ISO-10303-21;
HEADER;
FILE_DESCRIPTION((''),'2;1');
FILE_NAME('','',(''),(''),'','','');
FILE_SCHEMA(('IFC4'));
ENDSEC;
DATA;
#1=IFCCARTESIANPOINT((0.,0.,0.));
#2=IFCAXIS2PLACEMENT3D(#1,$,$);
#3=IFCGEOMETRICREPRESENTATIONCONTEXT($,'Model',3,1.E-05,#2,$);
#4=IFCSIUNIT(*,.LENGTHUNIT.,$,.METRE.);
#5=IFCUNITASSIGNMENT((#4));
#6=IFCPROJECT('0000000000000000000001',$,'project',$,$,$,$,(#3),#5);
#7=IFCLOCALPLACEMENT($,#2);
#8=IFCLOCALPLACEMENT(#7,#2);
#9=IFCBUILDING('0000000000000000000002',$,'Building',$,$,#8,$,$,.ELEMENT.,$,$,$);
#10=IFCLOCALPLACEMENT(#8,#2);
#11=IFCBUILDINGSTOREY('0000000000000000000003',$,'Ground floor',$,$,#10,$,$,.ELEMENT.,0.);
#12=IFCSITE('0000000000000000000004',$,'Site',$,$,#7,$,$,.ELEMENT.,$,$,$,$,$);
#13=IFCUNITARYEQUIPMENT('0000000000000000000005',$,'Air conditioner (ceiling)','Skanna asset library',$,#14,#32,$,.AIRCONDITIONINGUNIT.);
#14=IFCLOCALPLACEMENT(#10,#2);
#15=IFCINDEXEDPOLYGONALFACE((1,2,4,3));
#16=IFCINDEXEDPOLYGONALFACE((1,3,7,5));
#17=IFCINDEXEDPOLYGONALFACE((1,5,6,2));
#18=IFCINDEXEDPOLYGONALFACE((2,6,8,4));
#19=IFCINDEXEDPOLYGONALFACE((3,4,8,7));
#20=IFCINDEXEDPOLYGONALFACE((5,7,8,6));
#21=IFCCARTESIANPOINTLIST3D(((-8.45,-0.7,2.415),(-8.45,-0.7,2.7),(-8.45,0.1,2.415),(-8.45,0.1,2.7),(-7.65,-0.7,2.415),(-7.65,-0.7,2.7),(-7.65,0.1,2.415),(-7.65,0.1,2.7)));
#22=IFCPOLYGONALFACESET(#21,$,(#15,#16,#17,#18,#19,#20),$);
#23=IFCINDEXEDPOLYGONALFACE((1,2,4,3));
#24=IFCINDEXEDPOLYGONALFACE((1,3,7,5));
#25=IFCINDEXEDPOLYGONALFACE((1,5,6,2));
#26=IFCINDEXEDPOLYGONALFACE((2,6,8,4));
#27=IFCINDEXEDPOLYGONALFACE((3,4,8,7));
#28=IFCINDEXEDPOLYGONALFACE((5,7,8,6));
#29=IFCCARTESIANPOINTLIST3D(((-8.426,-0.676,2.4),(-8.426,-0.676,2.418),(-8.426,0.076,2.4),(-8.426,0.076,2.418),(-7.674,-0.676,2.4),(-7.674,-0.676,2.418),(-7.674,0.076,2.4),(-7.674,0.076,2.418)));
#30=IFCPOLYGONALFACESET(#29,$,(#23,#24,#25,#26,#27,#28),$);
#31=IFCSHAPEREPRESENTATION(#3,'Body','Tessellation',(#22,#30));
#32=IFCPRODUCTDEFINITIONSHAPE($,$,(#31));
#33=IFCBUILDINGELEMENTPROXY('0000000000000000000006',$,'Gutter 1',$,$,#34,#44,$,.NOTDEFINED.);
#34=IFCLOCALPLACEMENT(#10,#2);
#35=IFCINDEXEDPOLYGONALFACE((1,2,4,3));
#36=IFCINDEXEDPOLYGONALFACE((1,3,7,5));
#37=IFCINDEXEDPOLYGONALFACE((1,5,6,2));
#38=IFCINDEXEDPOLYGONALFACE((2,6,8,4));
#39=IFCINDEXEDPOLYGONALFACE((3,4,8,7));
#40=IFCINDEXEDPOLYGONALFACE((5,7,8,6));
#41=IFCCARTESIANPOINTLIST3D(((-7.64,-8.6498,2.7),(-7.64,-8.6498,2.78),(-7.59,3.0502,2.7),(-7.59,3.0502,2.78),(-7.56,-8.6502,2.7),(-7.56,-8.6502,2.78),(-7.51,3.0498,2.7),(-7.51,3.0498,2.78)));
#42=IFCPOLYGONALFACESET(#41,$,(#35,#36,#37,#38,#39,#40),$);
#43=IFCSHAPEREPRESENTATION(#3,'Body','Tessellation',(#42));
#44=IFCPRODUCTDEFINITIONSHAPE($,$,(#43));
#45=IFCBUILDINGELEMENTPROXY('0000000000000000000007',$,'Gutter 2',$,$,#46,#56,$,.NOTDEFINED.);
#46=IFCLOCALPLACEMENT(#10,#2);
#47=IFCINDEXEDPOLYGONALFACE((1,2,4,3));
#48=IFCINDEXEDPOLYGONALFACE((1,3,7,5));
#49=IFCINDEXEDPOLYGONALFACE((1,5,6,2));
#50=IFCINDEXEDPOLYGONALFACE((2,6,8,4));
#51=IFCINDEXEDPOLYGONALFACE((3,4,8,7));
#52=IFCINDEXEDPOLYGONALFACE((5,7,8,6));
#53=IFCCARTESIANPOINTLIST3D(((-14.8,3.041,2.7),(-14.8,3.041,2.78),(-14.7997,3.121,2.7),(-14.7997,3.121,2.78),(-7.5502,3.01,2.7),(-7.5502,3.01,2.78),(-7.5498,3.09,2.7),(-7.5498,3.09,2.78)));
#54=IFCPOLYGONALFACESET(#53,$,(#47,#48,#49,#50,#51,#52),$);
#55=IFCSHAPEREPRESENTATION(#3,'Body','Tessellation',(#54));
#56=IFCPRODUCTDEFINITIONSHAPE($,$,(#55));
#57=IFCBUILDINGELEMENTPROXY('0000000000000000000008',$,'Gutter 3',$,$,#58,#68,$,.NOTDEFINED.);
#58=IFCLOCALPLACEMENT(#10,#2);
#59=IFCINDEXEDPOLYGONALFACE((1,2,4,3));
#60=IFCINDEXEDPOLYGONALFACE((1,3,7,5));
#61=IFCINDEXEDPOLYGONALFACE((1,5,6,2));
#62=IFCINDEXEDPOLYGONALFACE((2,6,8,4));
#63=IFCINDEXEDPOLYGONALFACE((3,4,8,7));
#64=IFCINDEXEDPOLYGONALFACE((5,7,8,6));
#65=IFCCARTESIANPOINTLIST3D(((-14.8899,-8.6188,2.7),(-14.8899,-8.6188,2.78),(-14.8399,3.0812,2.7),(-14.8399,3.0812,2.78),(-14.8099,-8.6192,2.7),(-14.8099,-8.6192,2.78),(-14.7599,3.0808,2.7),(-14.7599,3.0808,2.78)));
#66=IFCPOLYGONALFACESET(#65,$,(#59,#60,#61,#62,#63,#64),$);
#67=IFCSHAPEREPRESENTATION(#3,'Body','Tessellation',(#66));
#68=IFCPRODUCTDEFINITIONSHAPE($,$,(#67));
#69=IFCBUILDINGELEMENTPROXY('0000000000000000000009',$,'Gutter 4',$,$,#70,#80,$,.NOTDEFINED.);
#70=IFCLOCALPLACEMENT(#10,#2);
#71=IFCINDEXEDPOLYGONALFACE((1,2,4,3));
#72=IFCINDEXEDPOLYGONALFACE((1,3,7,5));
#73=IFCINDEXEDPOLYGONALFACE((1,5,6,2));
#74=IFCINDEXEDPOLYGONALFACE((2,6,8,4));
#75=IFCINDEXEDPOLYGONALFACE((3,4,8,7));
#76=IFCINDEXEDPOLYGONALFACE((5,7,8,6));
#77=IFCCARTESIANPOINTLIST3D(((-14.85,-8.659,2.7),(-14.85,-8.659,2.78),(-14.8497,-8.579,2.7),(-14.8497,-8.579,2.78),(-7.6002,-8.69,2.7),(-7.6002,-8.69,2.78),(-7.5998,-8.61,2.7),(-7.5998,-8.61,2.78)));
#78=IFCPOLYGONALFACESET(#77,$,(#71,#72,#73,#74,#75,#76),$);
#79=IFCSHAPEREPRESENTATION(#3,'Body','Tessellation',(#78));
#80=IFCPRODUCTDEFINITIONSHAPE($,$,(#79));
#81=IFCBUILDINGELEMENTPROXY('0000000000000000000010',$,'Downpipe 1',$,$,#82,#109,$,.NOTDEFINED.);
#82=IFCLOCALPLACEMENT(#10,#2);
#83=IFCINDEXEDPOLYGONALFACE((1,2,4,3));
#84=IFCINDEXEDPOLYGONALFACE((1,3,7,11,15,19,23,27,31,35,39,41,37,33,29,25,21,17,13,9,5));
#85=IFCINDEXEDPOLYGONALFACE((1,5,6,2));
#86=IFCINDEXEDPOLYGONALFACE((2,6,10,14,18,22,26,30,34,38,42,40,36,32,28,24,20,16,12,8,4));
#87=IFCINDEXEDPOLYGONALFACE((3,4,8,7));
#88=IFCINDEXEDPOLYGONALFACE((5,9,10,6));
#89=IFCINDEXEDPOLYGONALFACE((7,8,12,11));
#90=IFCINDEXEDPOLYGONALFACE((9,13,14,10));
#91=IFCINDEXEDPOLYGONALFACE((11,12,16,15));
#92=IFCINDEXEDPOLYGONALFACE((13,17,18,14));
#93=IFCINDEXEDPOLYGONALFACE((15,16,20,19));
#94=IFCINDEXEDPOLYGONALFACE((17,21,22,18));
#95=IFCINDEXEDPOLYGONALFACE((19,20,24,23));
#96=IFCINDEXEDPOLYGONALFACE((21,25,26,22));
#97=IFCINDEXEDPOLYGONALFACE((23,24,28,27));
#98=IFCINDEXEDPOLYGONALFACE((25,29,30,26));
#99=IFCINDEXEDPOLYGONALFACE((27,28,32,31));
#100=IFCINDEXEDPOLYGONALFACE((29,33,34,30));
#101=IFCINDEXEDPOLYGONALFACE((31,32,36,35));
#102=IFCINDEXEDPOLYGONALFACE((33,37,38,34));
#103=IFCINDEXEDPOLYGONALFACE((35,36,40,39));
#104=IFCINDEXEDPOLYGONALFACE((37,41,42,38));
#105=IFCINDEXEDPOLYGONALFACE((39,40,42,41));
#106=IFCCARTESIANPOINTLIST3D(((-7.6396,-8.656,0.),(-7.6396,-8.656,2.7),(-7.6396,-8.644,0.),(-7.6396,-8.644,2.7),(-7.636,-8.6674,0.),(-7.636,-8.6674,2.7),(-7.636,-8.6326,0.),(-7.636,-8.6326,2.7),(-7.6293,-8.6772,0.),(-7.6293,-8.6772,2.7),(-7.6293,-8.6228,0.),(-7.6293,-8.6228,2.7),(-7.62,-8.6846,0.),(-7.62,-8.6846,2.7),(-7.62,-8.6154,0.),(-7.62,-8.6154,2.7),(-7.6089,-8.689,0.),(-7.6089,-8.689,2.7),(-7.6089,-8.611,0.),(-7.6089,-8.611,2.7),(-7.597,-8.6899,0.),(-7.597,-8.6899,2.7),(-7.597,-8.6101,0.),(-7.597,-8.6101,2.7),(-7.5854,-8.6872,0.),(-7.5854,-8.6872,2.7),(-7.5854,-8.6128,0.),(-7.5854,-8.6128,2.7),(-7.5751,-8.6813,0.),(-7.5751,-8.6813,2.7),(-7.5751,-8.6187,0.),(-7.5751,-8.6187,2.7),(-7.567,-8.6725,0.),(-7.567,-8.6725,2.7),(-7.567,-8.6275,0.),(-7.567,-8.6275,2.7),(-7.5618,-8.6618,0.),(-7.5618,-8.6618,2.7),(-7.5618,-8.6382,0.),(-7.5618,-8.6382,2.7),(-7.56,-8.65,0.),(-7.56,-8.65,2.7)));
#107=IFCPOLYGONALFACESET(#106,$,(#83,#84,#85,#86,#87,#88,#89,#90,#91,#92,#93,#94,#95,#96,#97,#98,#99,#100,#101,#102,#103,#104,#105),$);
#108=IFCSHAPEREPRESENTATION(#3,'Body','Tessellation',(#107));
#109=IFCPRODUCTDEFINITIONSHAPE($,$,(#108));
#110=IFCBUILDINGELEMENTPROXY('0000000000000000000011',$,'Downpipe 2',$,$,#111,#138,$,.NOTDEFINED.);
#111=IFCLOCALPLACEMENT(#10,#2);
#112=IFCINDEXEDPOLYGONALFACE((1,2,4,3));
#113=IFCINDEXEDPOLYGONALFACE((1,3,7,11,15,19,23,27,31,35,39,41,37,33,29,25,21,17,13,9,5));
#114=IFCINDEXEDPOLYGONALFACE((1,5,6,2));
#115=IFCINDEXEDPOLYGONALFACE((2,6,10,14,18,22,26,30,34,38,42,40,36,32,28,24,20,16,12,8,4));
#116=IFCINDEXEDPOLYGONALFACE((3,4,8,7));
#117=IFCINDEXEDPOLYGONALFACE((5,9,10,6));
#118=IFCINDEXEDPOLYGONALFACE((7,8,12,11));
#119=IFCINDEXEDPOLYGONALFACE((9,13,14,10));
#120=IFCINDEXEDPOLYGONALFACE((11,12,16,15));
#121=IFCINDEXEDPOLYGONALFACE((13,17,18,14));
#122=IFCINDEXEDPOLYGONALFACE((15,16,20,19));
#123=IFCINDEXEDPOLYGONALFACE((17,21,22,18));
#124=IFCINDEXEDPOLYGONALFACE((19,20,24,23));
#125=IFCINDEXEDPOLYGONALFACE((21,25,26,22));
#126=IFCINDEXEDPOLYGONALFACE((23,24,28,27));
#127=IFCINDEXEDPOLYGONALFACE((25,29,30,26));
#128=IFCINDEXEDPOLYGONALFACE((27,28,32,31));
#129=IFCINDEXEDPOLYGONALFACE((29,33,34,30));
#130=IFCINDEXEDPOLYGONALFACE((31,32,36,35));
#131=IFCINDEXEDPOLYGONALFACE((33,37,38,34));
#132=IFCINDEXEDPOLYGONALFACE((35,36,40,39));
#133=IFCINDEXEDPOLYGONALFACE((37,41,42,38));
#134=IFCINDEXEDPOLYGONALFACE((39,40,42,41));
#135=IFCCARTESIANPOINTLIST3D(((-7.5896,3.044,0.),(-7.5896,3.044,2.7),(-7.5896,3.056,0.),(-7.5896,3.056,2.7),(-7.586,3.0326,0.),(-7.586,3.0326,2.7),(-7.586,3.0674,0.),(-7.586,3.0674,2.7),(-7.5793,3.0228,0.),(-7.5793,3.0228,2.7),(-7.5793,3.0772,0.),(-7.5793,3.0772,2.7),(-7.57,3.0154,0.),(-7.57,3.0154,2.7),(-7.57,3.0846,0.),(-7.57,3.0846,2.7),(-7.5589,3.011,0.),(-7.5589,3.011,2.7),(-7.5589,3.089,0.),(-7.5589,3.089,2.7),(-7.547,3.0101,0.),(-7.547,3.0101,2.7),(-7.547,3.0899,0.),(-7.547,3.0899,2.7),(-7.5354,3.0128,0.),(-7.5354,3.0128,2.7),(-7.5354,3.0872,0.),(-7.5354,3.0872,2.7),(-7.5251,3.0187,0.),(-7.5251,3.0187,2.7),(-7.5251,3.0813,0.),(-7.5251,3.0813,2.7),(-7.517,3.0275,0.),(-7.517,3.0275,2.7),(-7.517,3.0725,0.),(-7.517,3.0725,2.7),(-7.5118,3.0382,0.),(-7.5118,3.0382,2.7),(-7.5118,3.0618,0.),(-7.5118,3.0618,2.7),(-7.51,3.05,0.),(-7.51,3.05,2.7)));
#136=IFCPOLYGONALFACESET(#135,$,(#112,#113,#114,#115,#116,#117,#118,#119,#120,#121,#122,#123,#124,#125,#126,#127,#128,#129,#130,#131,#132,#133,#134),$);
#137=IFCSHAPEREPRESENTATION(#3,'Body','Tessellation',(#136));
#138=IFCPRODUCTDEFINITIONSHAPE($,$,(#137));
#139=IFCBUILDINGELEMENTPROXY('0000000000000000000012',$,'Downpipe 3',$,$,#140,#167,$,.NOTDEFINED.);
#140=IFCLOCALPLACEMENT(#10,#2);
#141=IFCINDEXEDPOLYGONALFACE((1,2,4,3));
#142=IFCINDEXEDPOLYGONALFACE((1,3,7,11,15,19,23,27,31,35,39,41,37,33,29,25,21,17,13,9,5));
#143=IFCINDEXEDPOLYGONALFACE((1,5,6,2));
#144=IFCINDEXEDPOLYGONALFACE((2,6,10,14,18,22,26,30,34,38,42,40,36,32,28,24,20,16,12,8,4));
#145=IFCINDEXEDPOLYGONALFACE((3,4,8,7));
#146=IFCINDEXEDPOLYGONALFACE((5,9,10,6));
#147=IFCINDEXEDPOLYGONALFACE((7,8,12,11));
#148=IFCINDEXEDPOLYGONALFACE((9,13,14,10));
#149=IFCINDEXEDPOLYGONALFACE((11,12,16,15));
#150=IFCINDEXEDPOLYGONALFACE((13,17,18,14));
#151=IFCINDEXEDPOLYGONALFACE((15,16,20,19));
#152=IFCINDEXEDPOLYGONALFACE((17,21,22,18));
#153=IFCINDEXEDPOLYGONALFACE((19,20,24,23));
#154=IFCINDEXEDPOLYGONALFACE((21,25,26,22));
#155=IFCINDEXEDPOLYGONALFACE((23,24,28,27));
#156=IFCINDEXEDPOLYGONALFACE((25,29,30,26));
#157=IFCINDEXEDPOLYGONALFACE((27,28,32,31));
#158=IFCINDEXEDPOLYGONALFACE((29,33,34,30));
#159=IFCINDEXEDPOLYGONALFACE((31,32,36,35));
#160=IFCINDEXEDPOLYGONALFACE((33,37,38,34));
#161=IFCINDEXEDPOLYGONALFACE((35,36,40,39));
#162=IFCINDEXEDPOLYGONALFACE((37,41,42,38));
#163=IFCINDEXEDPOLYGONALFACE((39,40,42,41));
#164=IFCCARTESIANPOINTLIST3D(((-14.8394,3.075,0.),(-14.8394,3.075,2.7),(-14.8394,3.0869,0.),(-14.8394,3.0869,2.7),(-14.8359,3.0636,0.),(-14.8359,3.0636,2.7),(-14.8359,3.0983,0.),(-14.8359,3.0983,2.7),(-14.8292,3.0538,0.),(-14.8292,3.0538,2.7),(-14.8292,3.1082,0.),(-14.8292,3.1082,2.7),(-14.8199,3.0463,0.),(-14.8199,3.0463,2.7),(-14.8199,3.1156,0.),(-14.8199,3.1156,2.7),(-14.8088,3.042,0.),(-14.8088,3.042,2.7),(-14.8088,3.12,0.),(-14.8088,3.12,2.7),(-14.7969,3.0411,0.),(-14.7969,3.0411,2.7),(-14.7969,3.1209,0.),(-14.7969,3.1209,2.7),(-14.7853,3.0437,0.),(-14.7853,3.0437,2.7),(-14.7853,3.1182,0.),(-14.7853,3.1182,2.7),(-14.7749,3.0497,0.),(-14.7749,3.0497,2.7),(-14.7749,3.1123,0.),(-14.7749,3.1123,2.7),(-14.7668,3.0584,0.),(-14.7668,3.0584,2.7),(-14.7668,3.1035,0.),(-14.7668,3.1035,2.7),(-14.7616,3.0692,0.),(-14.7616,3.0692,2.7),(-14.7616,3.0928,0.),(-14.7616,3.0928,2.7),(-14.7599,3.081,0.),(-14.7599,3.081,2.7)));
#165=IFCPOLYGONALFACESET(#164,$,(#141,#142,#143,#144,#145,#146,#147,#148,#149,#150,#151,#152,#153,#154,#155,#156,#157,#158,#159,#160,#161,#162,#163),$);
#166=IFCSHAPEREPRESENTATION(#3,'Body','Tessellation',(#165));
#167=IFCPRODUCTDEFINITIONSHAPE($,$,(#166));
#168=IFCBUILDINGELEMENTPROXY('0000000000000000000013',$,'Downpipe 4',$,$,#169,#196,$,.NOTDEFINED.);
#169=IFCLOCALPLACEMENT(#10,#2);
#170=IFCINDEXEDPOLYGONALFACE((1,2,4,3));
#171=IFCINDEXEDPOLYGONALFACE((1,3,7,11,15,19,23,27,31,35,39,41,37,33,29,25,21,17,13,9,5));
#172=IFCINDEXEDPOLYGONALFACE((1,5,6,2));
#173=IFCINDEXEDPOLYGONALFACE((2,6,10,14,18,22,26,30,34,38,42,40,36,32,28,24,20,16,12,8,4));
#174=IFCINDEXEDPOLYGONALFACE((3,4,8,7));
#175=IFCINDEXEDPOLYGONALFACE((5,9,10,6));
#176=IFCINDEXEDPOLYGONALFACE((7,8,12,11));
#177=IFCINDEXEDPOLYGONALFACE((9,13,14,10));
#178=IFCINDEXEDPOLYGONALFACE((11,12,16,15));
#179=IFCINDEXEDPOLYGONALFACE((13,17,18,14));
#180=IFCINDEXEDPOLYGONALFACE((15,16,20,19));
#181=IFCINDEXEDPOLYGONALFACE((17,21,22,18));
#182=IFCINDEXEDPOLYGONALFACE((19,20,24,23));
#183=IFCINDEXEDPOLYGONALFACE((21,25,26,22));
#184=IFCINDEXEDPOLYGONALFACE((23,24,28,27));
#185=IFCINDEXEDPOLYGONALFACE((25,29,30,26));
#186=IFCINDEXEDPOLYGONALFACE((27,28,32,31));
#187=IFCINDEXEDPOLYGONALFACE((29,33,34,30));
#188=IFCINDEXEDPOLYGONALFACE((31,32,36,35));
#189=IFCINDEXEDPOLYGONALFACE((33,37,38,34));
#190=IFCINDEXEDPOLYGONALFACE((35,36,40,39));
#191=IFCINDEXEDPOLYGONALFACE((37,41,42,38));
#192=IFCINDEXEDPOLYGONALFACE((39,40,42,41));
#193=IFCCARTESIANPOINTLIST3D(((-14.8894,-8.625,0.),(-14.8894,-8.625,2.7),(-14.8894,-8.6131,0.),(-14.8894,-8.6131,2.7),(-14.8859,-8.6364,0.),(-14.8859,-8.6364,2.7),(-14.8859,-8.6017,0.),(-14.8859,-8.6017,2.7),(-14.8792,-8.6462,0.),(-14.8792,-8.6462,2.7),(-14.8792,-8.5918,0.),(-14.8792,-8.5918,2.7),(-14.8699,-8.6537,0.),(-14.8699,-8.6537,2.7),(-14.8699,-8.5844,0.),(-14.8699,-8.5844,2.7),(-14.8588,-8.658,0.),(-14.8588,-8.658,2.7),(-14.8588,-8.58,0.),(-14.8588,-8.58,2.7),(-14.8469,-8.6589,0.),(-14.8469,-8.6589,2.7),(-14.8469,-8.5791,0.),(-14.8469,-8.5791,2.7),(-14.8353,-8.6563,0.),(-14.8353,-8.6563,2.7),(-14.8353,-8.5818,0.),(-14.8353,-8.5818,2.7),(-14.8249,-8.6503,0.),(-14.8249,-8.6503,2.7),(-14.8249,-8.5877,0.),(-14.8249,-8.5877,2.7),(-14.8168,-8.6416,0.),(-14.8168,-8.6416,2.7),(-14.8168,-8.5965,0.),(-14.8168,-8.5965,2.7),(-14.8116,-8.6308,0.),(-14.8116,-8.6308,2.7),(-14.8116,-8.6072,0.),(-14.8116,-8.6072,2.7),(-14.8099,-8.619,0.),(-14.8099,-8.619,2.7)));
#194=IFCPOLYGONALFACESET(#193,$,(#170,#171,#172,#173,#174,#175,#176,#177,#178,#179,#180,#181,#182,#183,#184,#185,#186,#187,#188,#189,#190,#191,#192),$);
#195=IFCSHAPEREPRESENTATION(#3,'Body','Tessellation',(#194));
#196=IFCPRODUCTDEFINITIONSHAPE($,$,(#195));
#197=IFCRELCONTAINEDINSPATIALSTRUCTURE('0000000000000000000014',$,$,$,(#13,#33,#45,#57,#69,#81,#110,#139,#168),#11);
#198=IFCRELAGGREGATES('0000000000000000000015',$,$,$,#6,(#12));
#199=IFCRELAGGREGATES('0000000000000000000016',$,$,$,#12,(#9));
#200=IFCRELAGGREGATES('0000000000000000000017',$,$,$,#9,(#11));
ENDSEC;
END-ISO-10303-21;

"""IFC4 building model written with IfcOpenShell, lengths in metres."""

from ifc_helpers import new_model, si_unit, frame, frame_2d, origin, origin_2d, place, context, project, spatial, rectangle, circle, extrude, element, save


model = new_model("IFC4")

# Units and contexts
model_context = context("Model", 3, precision=1e-05, world=origin())
ifc_project = project(units=[si_unit("LENGTHUNIT", "METRE")], contexts=[model_context])

# Site, building, storey
site_placement = place(None, origin())
site = spatial("IfcSite", under=ifc_project, at=site_placement, Name="Site", CompositionType="ELEMENT")
building_placement = place(site_placement, origin())
building = spatial("IfcBuilding", under=site, at=building_placement, Name="Building", CompositionType="ELEMENT")
storey_placement = place(building_placement, origin())
storey = spatial("IfcBuildingStorey", under=building, at=storey_placement, Name="Ground floor", CompositionType="ELEMENT", Elevation=0.0)

# Unitary equipment
unitary_equipment_placement = place(storey_placement, frame((-8.05, -0.3, 2.4), z_axis=(0.0, 0.0, 1.0), x_axis=(1.0, 0.0, 0.0)))
element("IfcUnitaryEquipment", 1, at=unitary_equipment_placement, inside=storey, Name="Air conditioner (ceiling)", Description="Skanna asset library", PredefinedType="AIRCONDITIONINGUNIT", context=model_context, shape_type="SweptSolid", body=[
    extrude(rectangle(XDim=0.8, YDim=0.8, at=origin_2d()), frame((0.0, 0.0, 0.015)), (0.0, 0.0, 1.0), 0.285),
    extrude(rectangle(XDim=0.752, YDim=0.752, at=origin_2d()), origin(), (0.0, 0.0, 1.0), 0.018),
])

# Building element proxies
proxy_1_placement = place(storey_placement, frame((-7.6, -8.65, 2.7), z_axis=(0.0, 0.0, 1.0), x_axis=(0.004273, 0.999991, 0.0)))
element("IfcBuildingElementProxy", 2, at=proxy_1_placement, inside=storey, Name="Gutter 1", PredefinedType="NOTDEFINED", context=model_context, shape_type="SweptSolid", body=[
    extrude(rectangle(XDim=11.7001, YDim=0.08, at=frame_2d((5.8501, 0.0))), origin(), (0.0, 0.0, 1.0), 0.08),
])
proxy_2_placement = place(storey_placement, frame((-7.55, 3.05, 2.7), z_axis=(0.0, 0.0, 1.0), x_axis=(-0.999991, 0.004273, 0.0)))
element("IfcBuildingElementProxy", 3, at=proxy_2_placement, inside=storey, Name="Gutter 2", PredefinedType="NOTDEFINED", context=model_context, shape_type="SweptSolid", body=[
    extrude(rectangle(XDim=7.2499, YDim=0.08, at=frame_2d((3.625, 0.0))), origin(), (0.0, 0.0, 1.0), 0.08),
])
proxy_3_placement = place(storey_placement, frame((-14.7999, 3.081, 2.7), z_axis=(0.0, 0.0, 1.0), x_axis=(-0.004273, -0.999991, 0.0)))
element("IfcBuildingElementProxy", 4, at=proxy_3_placement, inside=storey, Name="Gutter 3", PredefinedType="NOTDEFINED", context=model_context, shape_type="SweptSolid", body=[
    extrude(rectangle(XDim=11.7001, YDim=0.08, at=frame_2d((5.8501, 0.0))), origin(), (0.0, 0.0, 1.0), 0.08),
])
proxy_4_placement = place(storey_placement, frame((-14.8499, -8.619, 2.7), z_axis=(0.0, 0.0, 1.0), x_axis=(0.999991, -0.004273, 0.0)))
element("IfcBuildingElementProxy", 5, at=proxy_4_placement, inside=storey, Name="Gutter 4", PredefinedType="NOTDEFINED", context=model_context, shape_type="SweptSolid", body=[
    extrude(rectangle(XDim=7.2499, YDim=0.08, at=frame_2d((3.625, 0.0))), origin(), (0.0, 0.0, 1.0), 0.08),
])
for number, where, z_axis, x_axis, name in (
    (6, (-7.6, -8.65, 0.0), (0.0, 0.0, 1.0), (1.0, 0.0, 0.0), "Downpipe 1"),
    (7, (-7.55, 3.05, 0.0), (0.0, 0.0, 1.0), (1.0, 0.0, 0.0), "Downpipe 2"),
    (8, (-14.7999, 3.081, 0.0), (0.0, 0.0, 1.0), (1.0, 0.0, 0.0), "Downpipe 3"),
    (9, (-14.8499, -8.619, 0.0), (0.0, 0.0, 1.0), (1.0, 0.0, 0.0), "Downpipe 4"),
):
    element("IfcBuildingElementProxy", number, at=place(storey_placement, frame(where, z_axis=z_axis, x_axis=x_axis)), inside=storey, Name=name, PredefinedType="NOTDEFINED", context=model_context, shape_type="SweptSolid", body=[
        extrude(circle(Radius=0.04, at=origin_2d()), origin(), (0.0, 0.0, 1.0), 2.7),
    ])

save(model, "model.ifc")
